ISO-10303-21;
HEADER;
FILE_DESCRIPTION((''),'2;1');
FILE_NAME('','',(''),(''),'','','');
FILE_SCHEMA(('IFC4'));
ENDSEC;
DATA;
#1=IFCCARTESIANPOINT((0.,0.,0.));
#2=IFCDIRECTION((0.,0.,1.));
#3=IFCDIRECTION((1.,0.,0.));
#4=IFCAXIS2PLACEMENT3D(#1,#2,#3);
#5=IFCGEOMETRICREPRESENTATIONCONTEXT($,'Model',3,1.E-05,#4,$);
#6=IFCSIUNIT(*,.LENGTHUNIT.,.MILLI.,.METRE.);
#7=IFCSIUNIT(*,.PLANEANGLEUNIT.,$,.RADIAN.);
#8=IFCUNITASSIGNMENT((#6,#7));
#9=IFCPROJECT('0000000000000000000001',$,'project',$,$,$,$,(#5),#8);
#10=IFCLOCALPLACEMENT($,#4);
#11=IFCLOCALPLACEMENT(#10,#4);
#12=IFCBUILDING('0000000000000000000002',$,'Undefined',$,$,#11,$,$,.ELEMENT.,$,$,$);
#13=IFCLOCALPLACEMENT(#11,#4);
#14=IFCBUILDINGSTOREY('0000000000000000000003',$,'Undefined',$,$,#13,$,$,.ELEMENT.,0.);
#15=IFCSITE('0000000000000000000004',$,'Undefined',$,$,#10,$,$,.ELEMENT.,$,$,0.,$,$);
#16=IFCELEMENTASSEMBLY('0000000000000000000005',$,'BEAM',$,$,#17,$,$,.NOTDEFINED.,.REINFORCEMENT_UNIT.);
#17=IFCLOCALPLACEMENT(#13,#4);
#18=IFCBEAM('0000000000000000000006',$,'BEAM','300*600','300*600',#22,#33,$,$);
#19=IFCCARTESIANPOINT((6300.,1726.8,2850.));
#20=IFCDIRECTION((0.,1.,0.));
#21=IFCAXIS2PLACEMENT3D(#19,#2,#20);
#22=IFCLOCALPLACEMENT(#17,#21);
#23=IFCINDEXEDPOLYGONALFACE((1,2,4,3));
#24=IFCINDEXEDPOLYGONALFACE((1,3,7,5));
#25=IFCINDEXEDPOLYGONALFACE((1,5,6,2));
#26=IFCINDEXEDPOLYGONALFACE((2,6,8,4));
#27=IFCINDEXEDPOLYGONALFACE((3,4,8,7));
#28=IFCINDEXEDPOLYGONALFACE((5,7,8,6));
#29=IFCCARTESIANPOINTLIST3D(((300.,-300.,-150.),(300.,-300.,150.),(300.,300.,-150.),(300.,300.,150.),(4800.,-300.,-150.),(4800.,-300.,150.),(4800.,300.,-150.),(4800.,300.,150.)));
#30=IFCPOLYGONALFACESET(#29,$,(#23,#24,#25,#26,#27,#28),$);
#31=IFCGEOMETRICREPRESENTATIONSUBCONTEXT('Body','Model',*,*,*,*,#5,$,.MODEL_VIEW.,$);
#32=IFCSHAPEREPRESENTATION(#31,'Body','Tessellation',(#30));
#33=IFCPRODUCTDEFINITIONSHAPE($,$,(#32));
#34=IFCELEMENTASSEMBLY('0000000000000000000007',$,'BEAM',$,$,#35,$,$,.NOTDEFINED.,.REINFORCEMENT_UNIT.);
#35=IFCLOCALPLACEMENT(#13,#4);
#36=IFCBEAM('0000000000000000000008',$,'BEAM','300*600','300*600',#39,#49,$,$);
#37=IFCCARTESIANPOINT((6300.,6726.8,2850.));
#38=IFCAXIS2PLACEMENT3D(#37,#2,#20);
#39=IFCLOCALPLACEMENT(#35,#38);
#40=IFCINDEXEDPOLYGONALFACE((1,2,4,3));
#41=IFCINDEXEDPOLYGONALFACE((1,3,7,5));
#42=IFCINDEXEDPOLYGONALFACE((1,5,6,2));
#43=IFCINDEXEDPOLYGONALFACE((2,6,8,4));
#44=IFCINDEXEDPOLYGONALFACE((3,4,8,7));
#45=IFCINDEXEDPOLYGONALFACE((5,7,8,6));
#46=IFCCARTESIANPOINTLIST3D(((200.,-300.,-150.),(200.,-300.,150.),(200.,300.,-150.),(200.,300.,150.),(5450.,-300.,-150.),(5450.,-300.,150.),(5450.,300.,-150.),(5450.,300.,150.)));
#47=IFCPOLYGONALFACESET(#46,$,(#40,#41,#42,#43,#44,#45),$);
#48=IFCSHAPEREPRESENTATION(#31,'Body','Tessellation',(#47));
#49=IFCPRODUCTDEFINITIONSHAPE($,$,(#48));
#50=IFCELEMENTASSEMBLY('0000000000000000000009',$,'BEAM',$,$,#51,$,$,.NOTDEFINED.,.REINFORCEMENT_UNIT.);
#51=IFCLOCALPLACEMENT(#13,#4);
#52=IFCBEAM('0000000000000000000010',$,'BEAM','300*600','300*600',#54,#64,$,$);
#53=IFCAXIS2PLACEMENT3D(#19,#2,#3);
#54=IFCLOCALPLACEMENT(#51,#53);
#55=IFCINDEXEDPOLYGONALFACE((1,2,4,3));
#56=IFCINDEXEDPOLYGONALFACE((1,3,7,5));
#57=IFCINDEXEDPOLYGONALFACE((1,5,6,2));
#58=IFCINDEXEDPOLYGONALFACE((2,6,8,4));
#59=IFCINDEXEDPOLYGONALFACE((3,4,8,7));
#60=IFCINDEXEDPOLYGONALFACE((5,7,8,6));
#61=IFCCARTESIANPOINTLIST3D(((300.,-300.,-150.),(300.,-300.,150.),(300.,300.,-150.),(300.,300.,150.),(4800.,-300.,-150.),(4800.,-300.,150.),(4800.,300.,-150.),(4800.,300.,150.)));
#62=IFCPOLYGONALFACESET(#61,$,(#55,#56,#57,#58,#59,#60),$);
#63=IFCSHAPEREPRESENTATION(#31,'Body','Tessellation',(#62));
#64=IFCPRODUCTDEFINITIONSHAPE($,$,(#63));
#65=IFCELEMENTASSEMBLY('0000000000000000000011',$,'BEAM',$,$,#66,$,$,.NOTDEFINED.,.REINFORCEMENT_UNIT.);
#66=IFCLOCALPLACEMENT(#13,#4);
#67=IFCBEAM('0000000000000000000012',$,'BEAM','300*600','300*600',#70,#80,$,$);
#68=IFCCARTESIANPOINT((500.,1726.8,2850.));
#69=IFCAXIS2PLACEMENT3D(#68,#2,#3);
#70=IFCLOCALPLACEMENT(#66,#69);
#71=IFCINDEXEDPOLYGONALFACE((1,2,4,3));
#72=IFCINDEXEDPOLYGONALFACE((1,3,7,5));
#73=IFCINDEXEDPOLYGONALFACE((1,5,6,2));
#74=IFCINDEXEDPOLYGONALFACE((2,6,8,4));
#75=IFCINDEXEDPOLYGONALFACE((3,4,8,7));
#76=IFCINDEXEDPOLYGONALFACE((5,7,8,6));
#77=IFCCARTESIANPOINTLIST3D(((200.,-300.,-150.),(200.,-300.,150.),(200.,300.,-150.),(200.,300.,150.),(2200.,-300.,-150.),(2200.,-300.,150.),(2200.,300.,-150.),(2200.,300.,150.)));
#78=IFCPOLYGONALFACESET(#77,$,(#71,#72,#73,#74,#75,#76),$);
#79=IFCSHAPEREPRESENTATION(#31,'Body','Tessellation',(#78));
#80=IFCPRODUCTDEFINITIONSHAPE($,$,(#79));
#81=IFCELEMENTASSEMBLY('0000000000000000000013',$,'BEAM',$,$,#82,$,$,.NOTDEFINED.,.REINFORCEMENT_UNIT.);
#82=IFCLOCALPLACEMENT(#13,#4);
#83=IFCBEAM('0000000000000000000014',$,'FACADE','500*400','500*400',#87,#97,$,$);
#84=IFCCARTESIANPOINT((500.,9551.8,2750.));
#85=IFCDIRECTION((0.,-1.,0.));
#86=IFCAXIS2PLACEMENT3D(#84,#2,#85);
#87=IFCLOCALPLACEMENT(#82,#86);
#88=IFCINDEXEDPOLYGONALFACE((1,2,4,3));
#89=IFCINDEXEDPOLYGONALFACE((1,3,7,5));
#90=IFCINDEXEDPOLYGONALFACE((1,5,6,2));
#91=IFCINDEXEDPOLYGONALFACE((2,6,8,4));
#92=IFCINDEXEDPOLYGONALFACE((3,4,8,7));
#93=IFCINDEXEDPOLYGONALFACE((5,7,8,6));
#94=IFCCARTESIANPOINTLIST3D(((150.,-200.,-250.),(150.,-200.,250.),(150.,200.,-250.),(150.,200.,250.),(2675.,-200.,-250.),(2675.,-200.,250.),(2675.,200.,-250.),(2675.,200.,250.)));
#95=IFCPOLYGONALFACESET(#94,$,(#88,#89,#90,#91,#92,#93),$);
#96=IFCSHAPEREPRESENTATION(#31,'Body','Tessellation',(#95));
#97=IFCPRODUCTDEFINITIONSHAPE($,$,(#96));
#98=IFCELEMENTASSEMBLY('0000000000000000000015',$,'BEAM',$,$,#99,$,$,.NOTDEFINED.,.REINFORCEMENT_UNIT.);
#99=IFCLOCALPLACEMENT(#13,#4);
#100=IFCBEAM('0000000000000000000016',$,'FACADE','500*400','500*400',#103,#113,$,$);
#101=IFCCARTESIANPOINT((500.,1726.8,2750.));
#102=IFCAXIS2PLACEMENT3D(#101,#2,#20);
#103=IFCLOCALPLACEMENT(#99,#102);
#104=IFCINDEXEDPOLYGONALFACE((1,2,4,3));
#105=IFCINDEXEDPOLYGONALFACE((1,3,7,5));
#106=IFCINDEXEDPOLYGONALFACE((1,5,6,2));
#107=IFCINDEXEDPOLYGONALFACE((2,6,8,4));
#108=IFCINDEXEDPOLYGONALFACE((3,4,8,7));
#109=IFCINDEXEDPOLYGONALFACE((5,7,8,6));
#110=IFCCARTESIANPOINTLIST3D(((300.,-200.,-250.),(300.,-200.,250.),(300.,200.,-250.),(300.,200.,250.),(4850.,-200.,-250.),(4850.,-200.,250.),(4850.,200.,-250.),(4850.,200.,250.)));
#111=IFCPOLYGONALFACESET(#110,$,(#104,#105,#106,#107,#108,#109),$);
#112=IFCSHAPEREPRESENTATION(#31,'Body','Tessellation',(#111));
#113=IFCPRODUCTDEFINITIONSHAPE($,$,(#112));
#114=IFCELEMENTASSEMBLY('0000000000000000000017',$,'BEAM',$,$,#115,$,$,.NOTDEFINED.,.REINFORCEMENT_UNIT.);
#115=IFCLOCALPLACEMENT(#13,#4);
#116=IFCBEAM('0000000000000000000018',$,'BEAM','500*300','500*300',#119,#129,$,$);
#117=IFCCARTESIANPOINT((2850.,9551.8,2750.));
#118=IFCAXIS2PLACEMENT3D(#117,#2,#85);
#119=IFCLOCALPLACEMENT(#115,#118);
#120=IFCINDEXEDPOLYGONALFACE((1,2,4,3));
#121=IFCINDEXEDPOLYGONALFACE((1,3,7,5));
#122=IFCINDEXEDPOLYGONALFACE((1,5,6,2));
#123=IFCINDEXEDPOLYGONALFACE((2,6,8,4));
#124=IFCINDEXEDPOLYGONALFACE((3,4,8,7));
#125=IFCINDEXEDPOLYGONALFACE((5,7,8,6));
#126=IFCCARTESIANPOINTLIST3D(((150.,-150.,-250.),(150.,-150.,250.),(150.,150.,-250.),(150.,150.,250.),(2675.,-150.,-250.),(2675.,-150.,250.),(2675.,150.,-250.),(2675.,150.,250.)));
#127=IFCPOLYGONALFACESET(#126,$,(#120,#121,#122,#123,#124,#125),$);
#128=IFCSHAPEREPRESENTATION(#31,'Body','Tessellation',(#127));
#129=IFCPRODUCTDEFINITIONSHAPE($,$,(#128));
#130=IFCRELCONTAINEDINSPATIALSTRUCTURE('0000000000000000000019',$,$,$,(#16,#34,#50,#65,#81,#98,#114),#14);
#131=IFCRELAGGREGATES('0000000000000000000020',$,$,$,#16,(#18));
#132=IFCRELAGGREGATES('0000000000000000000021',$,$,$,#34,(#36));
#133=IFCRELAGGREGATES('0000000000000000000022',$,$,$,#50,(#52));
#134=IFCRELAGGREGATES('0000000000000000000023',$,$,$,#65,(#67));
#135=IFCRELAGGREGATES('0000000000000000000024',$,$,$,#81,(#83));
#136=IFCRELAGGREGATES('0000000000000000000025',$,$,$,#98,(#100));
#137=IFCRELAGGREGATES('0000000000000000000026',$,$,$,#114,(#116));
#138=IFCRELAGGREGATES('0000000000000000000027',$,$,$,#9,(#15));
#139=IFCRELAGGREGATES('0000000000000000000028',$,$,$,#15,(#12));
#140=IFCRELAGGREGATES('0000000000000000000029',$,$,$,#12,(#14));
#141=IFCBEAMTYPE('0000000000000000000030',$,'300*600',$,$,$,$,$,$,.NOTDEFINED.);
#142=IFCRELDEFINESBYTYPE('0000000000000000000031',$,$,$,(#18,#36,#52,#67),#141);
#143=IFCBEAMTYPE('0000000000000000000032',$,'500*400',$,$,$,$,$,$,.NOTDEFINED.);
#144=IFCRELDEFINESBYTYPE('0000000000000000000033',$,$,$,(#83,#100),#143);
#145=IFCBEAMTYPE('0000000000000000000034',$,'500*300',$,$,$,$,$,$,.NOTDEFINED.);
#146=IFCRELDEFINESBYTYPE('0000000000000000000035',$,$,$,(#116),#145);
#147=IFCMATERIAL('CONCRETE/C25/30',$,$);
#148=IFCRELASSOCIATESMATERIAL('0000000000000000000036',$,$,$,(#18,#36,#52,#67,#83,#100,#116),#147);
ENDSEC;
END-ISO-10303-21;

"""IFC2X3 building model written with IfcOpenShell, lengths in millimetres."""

from ifc_helpers import new_model, si_unit, frame, origin_with_axes, origin_2d_with_axis, place, context, subcontext, project, spatial, rectangle, extrude, material, type_object, element, aggregate, save


model = new_model("IFC2X3")

# Units and contexts
model_context = context("Model", 3, precision=1e-05, world=origin_with_axes())
body_context = subcontext(model_context, "Body", "Model", "MODEL_VIEW")
ifc_project = project(units=[si_unit("LENGTHUNIT", "METRE", prefix="MILLI"), si_unit("PLANEANGLEUNIT", "RADIAN")], contexts=[model_context])

# Site, building, storey
site_placement = place(None, origin_with_axes())
site = spatial("IfcSite", under=ifc_project, at=site_placement, Name="Undefined", CompositionType="ELEMENT", RefElevation=0.0)
building_placement = place(site_placement, origin_with_axes())
building = spatial("IfcBuilding", under=site, at=building_placement, Name="Undefined", CompositionType="ELEMENT")
storey_placement = place(building_placement, origin_with_axes())
storey = spatial("IfcBuildingStorey", under=building, at=storey_placement, Name="Undefined", CompositionType="ELEMENT", Elevation=0.0)

# Shared definitions
ifc_material_1 = material(Name="CONCRETE/C25/30")

# Element assemblies, beams
assembly_1_placement = place(storey_placement, origin_with_axes())
assembly_1 = element("IfcElementAssembly", 1, at=assembly_1_placement, inside=storey, Name="BEAM", AssemblyPlace="NOTDEFINED", PredefinedType="REINFORCEMENT_UNIT")
beam_type_1 = type_object("IfcBeamType", Name="300*600", PredefinedType="NOTDEFINED")
beam_1_placement = place(assembly_1_placement, frame((6300.0, 1726.8, 2850.0), z_axis=(0.0, 0.0, 1.0), x_axis=(0.0, 1.0, 0.0)))
beam_1 = element("IfcBeam", 2, at=beam_1_placement, type_object=beam_type_1, material=ifc_material_1, Name="BEAM", Description="300*600", ObjectType="300*600", context=body_context, shape_type="SweptSolid", body=[
    extrude(rectangle(XDim=600.0, YDim=300.0, at=origin_2d_with_axis()), frame((4800.0, 0.0, 0.0), z_axis=(-1.0, 0.0, 0.0), x_axis=(0.0, -1.0, 0.0)), (0.0, 0.0, 1.0), 4500.0),
])
aggregate(assembly_1, [beam_1])
assembly_2_placement = place(storey_placement, origin_with_axes())
assembly_2 = element("IfcElementAssembly", 3, at=assembly_2_placement, inside=storey, Name="BEAM", AssemblyPlace="NOTDEFINED", PredefinedType="REINFORCEMENT_UNIT")
beam_2_placement = place(assembly_2_placement, frame((6300.0, 6726.8, 2850.0), z_axis=(0.0, 0.0, 1.0), x_axis=(0.0, 1.0, 0.0)))
beam_2 = element("IfcBeam", 4, at=beam_2_placement, type_object=beam_type_1, material=ifc_material_1, Name="BEAM", Description="300*600", ObjectType="300*600", context=body_context, shape_type="SweptSolid", body=[
    extrude(rectangle(XDim=600.0, YDim=300.0, at=origin_2d_with_axis()), frame((5450.0, 0.0, 0.0), z_axis=(-1.0, 0.0, 0.0), x_axis=(0.0, -1.0, 0.0)), (0.0, 0.0, 1.0), 5250.0),
])
aggregate(assembly_2, [beam_2])
assembly_3_placement = place(storey_placement, origin_with_axes())
assembly_3 = element("IfcElementAssembly", 5, at=assembly_3_placement, inside=storey, Name="BEAM", AssemblyPlace="NOTDEFINED", PredefinedType="REINFORCEMENT_UNIT")
beam_3_placement = place(assembly_3_placement, frame((6300.0, 1726.8, 2850.0), z_axis=(0.0, 0.0, 1.0), x_axis=(1.0, 0.0, 0.0)))
beam_3 = element("IfcBeam", 6, at=beam_3_placement, type_object=beam_type_1, material=ifc_material_1, Name="BEAM", Description="300*600", ObjectType="300*600", context=body_context, shape_type="SweptSolid", body=[
    extrude(rectangle(XDim=600.0, YDim=300.0, at=origin_2d_with_axis()), frame((4800.0, 0.0, 0.0), z_axis=(-1.0, 0.0, 0.0), x_axis=(0.0, -1.0, 0.0)), (0.0, 0.0, 1.0), 4500.0),
])
aggregate(assembly_3, [beam_3])
assembly_4_placement = place(storey_placement, origin_with_axes())
assembly_4 = element("IfcElementAssembly", 7, at=assembly_4_placement, inside=storey, Name="BEAM", AssemblyPlace="NOTDEFINED", PredefinedType="REINFORCEMENT_UNIT")
beam_4_placement = place(assembly_4_placement, frame((500.0, 1726.8, 2850.0), z_axis=(0.0, 0.0, 1.0), x_axis=(1.0, 0.0, 0.0)))
beam_4 = element("IfcBeam", 8, at=beam_4_placement, type_object=beam_type_1, material=ifc_material_1, Name="BEAM", Description="300*600", ObjectType="300*600", context=body_context, shape_type="SweptSolid", body=[
    extrude(rectangle(XDim=600.0, YDim=300.0, at=origin_2d_with_axis()), frame((2200.0, 0.0, 0.0), z_axis=(-1.0, 0.0, 0.0), x_axis=(0.0, -1.0, 0.0)), (0.0, 0.0, 1.0), 2000.0),
])
aggregate(assembly_4, [beam_4])
assembly_5_placement = place(storey_placement, origin_with_axes())
assembly_5 = element("IfcElementAssembly", 9, at=assembly_5_placement, inside=storey, Name="BEAM", AssemblyPlace="NOTDEFINED", PredefinedType="REINFORCEMENT_UNIT")
beam_type_2 = type_object("IfcBeamType", Name="500*400", PredefinedType="NOTDEFINED")
beam_5_placement = place(assembly_5_placement, frame((500.0, 9551.8, 2750.0), z_axis=(0.0, 0.0, 1.0), x_axis=(0.0, -1.0, 0.0)))
beam_5 = element("IfcBeam", 10, at=beam_5_placement, type_object=beam_type_2, material=ifc_material_1, Name="FACADE", Description="500*400", ObjectType="500*400", context=body_context, shape_type="SweptSolid", body=[
    extrude(rectangle(XDim=400.0, YDim=500.0, at=origin_2d_with_axis()), frame((2675.0, 0.0, 0.0), z_axis=(-1.0, 0.0, 0.0), x_axis=(0.0, -1.0, 0.0)), (0.0, 0.0, 1.0), 2525.0),
])
aggregate(assembly_5, [beam_5])
assembly_6_placement = place(storey_placement, origin_with_axes())
assembly_6 = element("IfcElementAssembly", 11, at=assembly_6_placement, inside=storey, Name="BEAM", AssemblyPlace="NOTDEFINED", PredefinedType="REINFORCEMENT_UNIT")
beam_6_placement = place(assembly_6_placement, frame((500.0, 1726.8, 2750.0), z_axis=(0.0, 0.0, 1.0), x_axis=(0.0, 1.0, 0.0)))
beam_6 = element("IfcBeam", 12, at=beam_6_placement, type_object=beam_type_2, material=ifc_material_1, Name="FACADE", Description="500*400", ObjectType="500*400", context=body_context, shape_type="SweptSolid", body=[
    extrude(rectangle(XDim=400.0, YDim=500.0, at=origin_2d_with_axis()), frame((4850.0, 0.0, 0.0), z_axis=(-1.0, 0.0, 0.0), x_axis=(0.0, -1.0, 0.0)), (0.0, 0.0, 1.0), 4550.0),
])
aggregate(assembly_6, [beam_6])
assembly_7_placement = place(storey_placement, origin_with_axes())
assembly_7 = element("IfcElementAssembly", 13, at=assembly_7_placement, inside=storey, Name="BEAM", AssemblyPlace="NOTDEFINED", PredefinedType="REINFORCEMENT_UNIT")
beam_type_3 = type_object("IfcBeamType", Name="500*300", PredefinedType="NOTDEFINED")
beam_7_placement = place(assembly_7_placement, frame((2850.0, 9551.8, 2750.0), z_axis=(0.0, 0.0, 1.0), x_axis=(0.0, -1.0, 0.0)))
beam_7 = element("IfcBeam", 14, at=beam_7_placement, type_object=beam_type_3, material=ifc_material_1, Name="BEAM", Description="500*300", ObjectType="500*300", context=body_context, shape_type="SweptSolid", body=[
    extrude(rectangle(XDim=300.0, YDim=500.0, at=origin_2d_with_axis()), frame((2675.0, 0.0, 0.0), z_axis=(-1.0, 0.0, 0.0), x_axis=(0.0, -1.0, 0.0)), (0.0, 0.0, 1.0), 2525.0),
])
aggregate(assembly_7, [beam_7])

save(model, "model.ifc")
